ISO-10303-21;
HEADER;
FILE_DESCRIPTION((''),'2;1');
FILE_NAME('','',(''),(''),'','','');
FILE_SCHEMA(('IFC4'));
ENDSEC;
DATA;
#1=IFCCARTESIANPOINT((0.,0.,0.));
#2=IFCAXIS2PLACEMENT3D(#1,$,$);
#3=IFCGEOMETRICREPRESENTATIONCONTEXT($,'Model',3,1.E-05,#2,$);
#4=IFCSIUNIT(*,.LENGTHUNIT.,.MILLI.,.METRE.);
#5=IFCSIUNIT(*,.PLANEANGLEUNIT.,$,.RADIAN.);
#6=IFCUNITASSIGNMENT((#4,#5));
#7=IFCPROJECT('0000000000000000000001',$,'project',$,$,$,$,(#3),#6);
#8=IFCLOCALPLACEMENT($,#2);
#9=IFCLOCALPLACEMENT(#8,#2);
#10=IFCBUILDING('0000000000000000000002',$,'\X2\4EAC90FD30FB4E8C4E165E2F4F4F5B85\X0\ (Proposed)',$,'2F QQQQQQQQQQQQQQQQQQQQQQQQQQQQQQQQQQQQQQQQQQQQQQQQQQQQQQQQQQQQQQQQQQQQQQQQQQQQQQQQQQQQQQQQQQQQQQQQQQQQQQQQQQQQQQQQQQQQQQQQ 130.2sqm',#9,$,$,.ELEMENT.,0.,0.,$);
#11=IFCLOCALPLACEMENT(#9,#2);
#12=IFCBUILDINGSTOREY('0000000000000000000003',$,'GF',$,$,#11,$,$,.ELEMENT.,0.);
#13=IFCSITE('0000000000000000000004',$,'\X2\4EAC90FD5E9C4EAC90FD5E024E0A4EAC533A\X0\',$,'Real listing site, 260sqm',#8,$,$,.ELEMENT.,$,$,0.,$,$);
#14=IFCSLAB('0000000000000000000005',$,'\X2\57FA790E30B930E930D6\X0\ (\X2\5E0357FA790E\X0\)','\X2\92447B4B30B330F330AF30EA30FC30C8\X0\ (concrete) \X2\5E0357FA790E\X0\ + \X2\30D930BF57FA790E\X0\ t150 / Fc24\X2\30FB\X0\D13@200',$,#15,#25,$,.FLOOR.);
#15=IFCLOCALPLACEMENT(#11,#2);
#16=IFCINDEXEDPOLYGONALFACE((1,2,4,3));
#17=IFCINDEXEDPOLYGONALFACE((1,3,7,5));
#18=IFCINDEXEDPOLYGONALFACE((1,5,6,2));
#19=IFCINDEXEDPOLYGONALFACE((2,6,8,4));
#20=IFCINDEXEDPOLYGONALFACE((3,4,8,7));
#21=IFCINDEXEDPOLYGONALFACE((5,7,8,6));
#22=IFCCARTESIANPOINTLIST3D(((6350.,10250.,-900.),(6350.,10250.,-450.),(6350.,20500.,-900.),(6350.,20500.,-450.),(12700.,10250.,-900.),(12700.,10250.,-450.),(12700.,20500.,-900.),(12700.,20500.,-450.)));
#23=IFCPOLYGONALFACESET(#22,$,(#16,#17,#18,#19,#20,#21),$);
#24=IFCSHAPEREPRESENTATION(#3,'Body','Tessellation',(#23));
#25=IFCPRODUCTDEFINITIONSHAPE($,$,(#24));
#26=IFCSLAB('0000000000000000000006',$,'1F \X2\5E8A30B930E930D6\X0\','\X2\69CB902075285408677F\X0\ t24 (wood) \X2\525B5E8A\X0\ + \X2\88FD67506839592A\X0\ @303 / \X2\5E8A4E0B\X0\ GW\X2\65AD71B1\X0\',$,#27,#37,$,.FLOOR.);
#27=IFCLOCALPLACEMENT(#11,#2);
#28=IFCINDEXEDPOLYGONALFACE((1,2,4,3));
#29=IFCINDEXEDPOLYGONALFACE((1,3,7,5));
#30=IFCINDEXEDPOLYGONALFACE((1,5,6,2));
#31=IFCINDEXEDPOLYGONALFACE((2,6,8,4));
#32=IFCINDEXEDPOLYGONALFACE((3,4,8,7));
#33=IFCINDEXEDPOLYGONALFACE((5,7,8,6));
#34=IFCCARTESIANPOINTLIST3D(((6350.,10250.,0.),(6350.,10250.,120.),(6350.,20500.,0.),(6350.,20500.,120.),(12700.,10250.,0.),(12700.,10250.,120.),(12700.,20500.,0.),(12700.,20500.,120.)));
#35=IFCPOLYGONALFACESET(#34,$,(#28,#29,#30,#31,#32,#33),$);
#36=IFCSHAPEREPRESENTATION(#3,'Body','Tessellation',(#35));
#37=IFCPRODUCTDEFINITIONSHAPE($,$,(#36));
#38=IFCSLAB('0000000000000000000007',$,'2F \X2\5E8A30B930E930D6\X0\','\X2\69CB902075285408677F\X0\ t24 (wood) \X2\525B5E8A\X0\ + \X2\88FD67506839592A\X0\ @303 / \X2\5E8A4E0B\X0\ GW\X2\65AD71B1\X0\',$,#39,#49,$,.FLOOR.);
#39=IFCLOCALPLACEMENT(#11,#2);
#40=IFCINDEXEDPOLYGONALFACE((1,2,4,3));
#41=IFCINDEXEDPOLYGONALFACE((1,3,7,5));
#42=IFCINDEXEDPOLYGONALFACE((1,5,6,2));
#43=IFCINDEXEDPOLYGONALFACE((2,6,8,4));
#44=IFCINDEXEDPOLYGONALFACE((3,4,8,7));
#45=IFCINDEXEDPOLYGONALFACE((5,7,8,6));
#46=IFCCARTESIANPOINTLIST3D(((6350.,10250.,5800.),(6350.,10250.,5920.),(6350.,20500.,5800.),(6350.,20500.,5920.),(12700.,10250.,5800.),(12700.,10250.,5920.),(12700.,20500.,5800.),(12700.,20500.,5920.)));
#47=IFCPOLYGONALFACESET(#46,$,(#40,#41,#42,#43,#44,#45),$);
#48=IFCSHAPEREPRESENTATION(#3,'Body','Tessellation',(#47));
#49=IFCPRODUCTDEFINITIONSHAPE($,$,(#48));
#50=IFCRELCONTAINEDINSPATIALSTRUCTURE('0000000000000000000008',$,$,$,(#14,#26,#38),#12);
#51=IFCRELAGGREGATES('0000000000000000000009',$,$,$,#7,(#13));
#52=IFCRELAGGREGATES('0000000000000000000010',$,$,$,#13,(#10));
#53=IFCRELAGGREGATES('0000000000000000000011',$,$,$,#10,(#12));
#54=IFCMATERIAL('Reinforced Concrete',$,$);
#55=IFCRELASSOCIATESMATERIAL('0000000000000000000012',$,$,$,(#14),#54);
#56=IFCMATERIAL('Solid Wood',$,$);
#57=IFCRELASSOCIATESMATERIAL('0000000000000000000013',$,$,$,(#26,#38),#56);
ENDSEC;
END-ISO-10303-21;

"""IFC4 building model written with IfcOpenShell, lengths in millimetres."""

from ifc_helpers import new_model, si_unit, frame, frame_2d, origin, place, context, project, spatial, rectangle, extrude, material, element, save


model = new_model("IFC4")

# Units and contexts
model_context = context("Model", 3, precision=1e-05, world=origin())
ifc_project = project(units=[si_unit("LENGTHUNIT", "METRE", prefix="MILLI"), si_unit("PLANEANGLEUNIT", "RADIAN")], contexts=[model_context])

# Site, building, storey
site_placement = place(None, origin())
site = spatial("IfcSite", under=ifc_project, at=site_placement, Name="京都府京都市上京区", ObjectType="Real listing site, 260sqm", CompositionType="ELEMENT", RefElevation=0.0)
building_placement = place(site_placement, origin())
building = spatial("IfcBuilding", under=site, at=building_placement, Name="京都・二世帯住宅 (Proposed)", ObjectType="2F QQQQQQQQQQQQQQQQQQQQQQQQQQQQQQQQQQQQQQQQQQQQQQQQQQQQQQQQQQQQQQQQQQQQQQQQQQQQQQQQQQQQQQQQQQQQQQQQQQQQQQQQQQQQQQQQQQQQQQQQ 130.2sqm", CompositionType="ELEMENT", ElevationOfRefHeight=0.0, ElevationOfTerrain=0.0)
storey_placement = place(building_placement, origin())
storey = spatial("IfcBuildingStorey", under=building, at=storey_placement, Name="GF", CompositionType="ELEMENT", Elevation=0.0)

# Shared definitions
ifc_material_1 = material(Name="Solid Wood")

# Slabs
ifc_material_2 = material(Name="Reinforced Concrete")
slab_1_placement = place(storey_placement, frame((3175.0, 5125.0, -450.0)))
element("IfcSlab", 1, at=slab_1_placement, inside=storey, material=ifc_material_2, Name="基礎スラブ (布基礎)", Description="鉄筋コンクリート (concrete) 布基礎 + ベタ基礎 t150 / Fc24・D13@200", PredefinedType="FLOOR", context=model_context, shape_type="SweptSolid", body=[
    extrude(rectangle(XDim=6350.0, YDim=10250.0, at=frame_2d((3175.0, 5125.0))), frame((3175.0, 5125.0, -450.0)), (0.0, 0.0, 1.0), 450.0),
])
slab_2_placement = place(storey_placement, frame((3175.0, 5125.0, 0.0)))
element("IfcSlab", 2, at=slab_2_placement, inside=storey, material=ifc_material_1, Name="1F 床スラブ", Description="構造用合板 t24 (wood) 剛床 + 製材根太 @303 / 床下 GW断熱", PredefinedType="FLOOR", context=model_context, shape_type="SweptSolid", body=[
    extrude(rectangle(XDim=6350.0, YDim=10250.0, at=frame_2d((3175.0, 5125.0))), frame((3175.0, 5125.0, 0.0)), (0.0, 0.0, 1.0), 120.0),
])
slab_3_placement = place(storey_placement, frame((3175.0, 5125.0, 2900.0)))
element("IfcSlab", 3, at=slab_3_placement, inside=storey, material=ifc_material_1, Name="2F 床スラブ", Description="構造用合板 t24 (wood) 剛床 + 製材根太 @303 / 床下 GW断熱", PredefinedType="FLOOR", context=model_context, shape_type="SweptSolid", body=[
    extrude(rectangle(XDim=6350.0, YDim=10250.0, at=frame_2d((3175.0, 5125.0))), frame((3175.0, 5125.0, 2900.0)), (0.0, 0.0, 1.0), 120.0),
])

save(model, "model.ifc")
